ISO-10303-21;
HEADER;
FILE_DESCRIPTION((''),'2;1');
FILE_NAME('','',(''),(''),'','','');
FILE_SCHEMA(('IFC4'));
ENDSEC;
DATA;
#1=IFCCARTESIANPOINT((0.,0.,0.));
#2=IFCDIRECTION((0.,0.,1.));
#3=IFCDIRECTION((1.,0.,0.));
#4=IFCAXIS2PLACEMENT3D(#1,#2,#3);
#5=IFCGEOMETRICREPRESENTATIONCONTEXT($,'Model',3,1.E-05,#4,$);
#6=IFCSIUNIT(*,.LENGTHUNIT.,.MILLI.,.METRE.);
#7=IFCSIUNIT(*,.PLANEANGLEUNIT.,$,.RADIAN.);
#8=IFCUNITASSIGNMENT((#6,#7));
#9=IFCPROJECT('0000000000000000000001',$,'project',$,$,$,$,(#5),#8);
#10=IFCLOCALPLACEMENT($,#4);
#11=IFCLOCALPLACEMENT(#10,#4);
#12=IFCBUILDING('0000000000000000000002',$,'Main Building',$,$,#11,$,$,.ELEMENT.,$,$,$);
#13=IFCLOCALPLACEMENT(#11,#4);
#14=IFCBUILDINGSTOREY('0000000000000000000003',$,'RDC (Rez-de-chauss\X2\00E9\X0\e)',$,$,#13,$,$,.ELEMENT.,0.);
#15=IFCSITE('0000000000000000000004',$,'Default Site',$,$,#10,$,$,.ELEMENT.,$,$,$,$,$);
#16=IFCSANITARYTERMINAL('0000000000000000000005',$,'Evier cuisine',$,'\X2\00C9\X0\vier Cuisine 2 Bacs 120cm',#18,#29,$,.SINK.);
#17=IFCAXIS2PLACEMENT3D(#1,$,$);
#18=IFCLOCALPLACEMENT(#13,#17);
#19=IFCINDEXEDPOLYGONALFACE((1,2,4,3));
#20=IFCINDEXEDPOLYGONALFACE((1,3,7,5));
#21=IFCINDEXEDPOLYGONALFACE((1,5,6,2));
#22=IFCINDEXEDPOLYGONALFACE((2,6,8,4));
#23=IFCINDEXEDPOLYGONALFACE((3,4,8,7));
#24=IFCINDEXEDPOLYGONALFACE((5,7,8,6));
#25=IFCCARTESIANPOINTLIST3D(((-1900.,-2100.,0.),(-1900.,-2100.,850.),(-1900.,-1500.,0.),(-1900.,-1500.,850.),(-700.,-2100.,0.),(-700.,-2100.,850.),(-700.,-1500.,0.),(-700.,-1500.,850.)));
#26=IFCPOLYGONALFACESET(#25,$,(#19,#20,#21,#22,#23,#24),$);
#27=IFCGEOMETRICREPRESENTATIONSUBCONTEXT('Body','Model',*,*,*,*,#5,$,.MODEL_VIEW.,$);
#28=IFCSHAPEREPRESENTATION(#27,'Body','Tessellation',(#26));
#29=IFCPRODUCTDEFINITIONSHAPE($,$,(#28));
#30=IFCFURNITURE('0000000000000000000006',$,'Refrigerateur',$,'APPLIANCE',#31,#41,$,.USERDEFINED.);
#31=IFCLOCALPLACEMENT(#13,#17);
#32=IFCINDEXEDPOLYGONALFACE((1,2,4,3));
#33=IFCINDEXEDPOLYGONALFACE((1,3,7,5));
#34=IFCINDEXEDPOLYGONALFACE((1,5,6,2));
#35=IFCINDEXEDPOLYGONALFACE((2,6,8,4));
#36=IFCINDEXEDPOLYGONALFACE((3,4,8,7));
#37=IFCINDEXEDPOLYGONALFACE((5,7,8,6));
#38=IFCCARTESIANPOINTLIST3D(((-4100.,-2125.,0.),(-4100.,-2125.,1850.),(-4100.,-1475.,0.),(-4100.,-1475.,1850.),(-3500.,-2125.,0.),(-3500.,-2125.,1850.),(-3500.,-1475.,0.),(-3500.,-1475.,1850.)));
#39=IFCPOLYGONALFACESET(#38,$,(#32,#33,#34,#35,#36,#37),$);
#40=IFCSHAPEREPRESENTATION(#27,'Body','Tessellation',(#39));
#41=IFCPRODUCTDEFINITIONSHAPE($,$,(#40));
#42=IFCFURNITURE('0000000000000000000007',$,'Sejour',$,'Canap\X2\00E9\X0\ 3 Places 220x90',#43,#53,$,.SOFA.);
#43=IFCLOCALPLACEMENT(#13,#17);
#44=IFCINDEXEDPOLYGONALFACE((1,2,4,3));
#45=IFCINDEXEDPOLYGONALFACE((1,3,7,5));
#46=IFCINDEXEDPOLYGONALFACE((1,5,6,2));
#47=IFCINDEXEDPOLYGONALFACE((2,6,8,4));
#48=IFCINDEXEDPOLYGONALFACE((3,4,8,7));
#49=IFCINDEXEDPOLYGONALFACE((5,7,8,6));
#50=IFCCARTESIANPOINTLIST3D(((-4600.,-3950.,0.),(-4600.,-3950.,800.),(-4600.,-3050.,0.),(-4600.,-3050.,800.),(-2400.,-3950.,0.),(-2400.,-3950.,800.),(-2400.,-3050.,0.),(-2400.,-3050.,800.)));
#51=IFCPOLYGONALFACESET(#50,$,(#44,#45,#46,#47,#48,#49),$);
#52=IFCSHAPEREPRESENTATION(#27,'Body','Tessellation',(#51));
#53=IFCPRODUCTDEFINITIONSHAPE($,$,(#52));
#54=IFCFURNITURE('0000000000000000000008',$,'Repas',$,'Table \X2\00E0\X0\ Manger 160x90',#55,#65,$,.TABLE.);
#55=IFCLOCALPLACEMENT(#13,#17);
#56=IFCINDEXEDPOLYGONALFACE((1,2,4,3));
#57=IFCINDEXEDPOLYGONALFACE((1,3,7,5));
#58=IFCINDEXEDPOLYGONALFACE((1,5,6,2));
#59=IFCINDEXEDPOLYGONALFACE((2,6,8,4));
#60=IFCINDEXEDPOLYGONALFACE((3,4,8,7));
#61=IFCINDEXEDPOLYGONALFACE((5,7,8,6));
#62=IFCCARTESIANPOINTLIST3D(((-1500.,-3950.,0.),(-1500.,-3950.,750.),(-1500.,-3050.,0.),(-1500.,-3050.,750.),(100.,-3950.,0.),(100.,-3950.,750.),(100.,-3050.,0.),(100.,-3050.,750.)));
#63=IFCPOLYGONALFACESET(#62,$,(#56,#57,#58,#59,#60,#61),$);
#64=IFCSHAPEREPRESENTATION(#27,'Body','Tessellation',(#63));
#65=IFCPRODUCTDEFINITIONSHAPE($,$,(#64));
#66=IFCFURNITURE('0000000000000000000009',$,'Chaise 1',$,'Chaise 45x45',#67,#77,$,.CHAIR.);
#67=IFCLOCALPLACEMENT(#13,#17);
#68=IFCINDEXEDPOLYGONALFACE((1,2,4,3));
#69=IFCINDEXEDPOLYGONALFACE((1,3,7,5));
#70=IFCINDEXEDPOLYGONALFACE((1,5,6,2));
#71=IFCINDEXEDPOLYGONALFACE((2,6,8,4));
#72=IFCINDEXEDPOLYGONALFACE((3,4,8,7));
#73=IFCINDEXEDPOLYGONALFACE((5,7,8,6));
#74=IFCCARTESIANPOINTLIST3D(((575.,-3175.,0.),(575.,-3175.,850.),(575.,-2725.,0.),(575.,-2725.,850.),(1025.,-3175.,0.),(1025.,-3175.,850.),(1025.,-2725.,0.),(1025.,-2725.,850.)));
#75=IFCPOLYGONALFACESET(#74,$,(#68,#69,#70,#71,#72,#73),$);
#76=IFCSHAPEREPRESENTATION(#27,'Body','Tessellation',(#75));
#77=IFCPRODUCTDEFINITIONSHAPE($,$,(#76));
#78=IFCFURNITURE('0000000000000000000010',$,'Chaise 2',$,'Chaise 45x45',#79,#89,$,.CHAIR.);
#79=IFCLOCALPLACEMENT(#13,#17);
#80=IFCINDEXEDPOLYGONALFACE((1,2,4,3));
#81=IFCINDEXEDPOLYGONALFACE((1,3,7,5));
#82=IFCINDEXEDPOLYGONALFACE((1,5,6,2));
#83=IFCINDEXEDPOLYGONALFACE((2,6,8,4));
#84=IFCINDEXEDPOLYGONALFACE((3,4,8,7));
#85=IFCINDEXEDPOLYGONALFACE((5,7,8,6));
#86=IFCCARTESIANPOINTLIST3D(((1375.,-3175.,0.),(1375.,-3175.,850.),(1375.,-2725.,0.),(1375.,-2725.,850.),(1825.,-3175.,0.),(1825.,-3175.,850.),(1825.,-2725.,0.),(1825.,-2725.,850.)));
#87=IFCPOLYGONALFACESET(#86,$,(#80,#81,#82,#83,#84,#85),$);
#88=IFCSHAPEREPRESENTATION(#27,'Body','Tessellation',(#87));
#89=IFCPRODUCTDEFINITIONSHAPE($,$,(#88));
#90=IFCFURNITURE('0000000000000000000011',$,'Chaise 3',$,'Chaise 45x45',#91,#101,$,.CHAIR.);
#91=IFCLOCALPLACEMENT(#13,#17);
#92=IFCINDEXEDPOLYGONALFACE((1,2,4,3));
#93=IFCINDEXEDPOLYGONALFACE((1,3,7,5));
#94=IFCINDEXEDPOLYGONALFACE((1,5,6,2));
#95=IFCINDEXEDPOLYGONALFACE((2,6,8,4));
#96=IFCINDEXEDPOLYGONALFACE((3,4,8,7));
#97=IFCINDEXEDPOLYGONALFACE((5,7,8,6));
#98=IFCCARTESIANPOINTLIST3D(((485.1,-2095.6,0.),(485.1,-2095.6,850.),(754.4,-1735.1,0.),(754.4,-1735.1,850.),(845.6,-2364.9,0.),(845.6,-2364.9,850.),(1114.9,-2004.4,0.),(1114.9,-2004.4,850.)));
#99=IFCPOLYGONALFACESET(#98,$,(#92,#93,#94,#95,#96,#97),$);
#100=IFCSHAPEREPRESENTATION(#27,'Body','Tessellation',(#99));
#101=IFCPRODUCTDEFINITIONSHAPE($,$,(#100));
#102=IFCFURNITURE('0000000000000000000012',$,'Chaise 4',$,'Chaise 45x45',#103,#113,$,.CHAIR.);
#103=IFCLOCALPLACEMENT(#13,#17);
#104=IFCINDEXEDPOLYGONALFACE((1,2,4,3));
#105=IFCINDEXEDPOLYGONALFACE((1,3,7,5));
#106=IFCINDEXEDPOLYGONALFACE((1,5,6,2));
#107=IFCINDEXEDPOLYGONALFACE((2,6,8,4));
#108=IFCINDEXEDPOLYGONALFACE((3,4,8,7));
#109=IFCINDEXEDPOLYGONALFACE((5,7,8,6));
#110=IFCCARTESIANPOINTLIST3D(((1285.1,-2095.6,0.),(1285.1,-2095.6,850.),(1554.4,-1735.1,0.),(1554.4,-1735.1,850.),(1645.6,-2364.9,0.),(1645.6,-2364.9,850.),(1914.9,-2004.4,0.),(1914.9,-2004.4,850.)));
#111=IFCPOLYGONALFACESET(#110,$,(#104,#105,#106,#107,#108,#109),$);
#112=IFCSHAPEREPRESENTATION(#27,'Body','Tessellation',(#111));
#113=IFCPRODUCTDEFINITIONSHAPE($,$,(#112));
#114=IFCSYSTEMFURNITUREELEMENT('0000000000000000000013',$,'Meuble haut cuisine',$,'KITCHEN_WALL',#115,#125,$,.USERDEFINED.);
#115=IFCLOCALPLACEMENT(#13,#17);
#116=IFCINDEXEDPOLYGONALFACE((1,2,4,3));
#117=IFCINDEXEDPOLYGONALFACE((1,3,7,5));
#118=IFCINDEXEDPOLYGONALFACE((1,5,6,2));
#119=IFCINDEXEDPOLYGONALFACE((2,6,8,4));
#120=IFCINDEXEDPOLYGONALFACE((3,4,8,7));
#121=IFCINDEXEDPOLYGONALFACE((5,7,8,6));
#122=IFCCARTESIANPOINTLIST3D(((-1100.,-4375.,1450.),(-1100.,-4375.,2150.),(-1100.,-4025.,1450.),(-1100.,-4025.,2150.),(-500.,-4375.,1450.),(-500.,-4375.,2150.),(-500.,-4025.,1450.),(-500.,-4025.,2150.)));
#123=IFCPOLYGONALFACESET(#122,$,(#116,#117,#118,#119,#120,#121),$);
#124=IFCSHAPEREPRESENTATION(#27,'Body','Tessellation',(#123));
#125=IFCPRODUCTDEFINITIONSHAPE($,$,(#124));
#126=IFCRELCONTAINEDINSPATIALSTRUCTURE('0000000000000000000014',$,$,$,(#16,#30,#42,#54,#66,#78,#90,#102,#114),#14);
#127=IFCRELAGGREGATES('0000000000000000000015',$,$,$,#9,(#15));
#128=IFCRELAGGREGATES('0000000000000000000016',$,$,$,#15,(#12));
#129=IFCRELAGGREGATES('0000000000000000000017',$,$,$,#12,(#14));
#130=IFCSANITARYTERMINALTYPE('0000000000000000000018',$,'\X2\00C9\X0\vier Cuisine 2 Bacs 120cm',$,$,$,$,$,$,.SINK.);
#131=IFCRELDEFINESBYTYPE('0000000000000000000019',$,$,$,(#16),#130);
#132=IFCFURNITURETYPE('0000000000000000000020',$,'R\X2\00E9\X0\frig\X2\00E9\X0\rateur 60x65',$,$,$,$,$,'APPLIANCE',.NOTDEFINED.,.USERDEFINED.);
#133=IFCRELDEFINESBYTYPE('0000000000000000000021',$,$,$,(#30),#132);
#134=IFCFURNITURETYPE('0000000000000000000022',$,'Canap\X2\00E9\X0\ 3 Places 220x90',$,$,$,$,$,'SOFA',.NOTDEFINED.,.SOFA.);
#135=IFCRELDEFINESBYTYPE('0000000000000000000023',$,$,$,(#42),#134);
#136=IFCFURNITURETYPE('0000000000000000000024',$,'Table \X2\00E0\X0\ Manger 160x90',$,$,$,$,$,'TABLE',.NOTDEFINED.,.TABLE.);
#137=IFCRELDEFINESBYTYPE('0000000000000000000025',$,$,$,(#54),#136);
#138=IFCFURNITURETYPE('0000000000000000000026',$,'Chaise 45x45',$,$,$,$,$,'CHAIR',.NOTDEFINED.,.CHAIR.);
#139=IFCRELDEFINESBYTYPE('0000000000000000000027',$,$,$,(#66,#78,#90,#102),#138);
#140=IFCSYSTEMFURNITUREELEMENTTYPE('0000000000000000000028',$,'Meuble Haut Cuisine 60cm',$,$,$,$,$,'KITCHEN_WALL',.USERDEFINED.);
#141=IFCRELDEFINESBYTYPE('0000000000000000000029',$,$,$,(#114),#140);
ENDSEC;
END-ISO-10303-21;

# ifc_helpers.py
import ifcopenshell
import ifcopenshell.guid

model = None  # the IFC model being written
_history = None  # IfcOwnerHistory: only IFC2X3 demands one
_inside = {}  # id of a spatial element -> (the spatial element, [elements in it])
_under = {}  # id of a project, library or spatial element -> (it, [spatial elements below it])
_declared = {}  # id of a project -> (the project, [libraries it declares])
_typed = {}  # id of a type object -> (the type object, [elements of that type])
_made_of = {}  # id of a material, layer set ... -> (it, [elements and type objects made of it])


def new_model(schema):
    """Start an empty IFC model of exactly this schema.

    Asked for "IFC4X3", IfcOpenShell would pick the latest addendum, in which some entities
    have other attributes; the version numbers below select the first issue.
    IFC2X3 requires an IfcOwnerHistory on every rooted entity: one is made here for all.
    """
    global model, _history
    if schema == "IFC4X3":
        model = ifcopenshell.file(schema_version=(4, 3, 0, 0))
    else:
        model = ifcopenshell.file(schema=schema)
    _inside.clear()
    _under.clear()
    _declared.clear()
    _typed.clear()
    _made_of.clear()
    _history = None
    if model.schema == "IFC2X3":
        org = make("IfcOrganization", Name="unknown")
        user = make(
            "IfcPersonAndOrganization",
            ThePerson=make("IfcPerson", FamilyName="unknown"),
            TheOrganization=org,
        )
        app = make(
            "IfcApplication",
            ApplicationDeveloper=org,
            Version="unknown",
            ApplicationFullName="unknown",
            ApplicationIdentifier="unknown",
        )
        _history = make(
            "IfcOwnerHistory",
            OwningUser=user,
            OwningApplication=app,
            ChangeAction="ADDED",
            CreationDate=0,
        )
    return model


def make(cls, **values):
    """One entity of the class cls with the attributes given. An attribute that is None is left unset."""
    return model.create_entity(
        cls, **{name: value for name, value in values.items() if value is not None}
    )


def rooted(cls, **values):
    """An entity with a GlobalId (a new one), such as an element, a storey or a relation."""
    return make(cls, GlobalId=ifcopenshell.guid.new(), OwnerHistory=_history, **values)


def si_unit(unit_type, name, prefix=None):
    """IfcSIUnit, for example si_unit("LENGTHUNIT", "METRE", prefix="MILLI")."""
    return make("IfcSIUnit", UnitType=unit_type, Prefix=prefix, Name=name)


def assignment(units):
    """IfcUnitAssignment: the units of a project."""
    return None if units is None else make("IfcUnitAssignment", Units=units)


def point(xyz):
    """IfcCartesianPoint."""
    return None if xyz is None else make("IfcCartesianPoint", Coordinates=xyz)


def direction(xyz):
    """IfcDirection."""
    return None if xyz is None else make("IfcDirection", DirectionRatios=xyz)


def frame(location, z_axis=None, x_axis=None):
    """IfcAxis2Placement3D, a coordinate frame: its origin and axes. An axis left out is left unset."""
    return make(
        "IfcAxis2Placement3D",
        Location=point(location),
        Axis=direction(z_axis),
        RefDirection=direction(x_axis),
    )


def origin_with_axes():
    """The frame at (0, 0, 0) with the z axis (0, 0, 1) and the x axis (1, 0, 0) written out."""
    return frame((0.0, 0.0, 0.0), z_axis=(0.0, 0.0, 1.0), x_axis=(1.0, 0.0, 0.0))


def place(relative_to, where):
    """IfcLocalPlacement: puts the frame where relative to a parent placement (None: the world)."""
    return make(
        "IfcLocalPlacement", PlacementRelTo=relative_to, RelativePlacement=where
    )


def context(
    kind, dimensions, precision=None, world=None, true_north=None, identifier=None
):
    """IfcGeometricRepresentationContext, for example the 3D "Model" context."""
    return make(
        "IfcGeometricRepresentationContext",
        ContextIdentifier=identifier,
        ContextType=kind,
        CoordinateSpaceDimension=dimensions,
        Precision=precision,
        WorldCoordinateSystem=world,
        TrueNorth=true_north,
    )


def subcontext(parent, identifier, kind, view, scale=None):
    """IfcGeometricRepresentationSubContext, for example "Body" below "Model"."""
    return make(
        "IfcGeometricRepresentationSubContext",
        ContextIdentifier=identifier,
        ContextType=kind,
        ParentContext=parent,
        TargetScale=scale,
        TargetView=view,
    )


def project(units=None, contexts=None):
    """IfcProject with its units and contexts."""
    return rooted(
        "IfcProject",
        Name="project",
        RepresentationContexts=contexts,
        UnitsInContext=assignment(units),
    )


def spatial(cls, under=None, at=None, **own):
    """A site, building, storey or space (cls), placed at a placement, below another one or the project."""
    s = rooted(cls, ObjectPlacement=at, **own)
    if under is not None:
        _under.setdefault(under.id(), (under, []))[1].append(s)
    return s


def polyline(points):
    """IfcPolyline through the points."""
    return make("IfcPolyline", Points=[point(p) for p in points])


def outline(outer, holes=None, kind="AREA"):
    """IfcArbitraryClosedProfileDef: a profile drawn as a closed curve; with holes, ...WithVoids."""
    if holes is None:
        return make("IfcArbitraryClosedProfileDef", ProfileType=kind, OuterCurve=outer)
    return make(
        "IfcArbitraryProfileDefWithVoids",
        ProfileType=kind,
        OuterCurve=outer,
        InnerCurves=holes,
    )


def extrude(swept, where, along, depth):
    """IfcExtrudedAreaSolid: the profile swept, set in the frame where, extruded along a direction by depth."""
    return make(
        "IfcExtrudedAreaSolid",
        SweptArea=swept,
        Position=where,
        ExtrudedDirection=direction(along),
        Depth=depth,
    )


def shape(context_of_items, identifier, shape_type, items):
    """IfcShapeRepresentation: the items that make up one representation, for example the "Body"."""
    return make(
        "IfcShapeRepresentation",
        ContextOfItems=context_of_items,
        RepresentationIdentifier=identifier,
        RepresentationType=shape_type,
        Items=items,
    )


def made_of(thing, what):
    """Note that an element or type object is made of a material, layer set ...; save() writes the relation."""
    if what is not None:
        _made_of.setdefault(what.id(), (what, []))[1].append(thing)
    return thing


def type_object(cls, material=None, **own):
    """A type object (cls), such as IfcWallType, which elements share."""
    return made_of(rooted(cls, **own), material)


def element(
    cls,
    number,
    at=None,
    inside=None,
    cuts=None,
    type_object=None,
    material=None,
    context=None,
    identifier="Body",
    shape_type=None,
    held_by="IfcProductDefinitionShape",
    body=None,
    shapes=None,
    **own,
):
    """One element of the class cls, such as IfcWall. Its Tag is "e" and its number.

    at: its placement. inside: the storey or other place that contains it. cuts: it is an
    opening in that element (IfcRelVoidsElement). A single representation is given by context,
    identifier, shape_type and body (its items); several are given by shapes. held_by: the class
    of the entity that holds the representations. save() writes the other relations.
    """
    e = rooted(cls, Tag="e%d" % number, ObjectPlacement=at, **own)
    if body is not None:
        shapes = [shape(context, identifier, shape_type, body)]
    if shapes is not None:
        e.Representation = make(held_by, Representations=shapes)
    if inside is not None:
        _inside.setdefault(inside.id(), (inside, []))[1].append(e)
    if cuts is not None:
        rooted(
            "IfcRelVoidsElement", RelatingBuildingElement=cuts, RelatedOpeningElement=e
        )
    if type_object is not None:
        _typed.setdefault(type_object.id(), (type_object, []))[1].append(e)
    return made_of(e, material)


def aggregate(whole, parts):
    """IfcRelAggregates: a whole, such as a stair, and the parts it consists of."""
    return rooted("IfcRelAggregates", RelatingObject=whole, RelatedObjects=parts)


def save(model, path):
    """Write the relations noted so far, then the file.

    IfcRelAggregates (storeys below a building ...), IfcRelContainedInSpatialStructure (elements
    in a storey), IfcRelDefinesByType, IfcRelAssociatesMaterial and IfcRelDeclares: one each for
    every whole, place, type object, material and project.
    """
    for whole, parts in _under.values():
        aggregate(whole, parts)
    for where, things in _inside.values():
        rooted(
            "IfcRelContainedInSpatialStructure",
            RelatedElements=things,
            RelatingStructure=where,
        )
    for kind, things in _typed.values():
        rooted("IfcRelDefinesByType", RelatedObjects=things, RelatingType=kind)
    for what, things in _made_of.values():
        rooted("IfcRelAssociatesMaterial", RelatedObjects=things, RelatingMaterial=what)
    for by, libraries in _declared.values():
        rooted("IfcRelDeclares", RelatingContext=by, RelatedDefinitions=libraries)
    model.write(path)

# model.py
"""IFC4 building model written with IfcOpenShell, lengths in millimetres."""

from ifc_helpers import new_model, si_unit, frame, origin_with_axes, place, context, subcontext, project, spatial, polyline, outline, extrude, type_object, element, save


model = new_model("IFC4")

# Units and contexts
model_context = context("Model", 3, precision=1e-05, world=origin_with_axes())
body_context = subcontext(model_context, "Body", "Model", "MODEL_VIEW")
ifc_project = project(units=[si_unit("LENGTHUNIT", "METRE", prefix="MILLI"), si_unit("PLANEANGLEUNIT", "RADIAN")], contexts=[model_context])

# Site, building, storey
site_placement = place(None, origin_with_axes())
site = spatial("IfcSite", under=ifc_project, at=site_placement, Name="Default Site", CompositionType="ELEMENT")
building_placement = place(site_placement, origin_with_axes())
building = spatial("IfcBuilding", under=site, at=building_placement, Name="Main Building", CompositionType="ELEMENT")
storey_placement = place(building_placement, origin_with_axes())
storey = spatial("IfcBuildingStorey", under=building, at=storey_placement, Name="RDC (Rez-de-chaussée)", CompositionType="ELEMENT", Elevation=0.0)

# Sanitary terminal
sanitary_terminal_type = type_object("IfcSanitaryTerminalType", Name="Évier Cuisine 2 Bacs 120cm", PredefinedType="SINK")
sanitary_terminal_placement = place(storey_placement, frame((-1300.0, -1800.0, 0.0), z_axis=(0.0, 0.0, 1.0), x_axis=(1.0, 0.0, 0.0)))
element("IfcSanitaryTerminal", 1, at=sanitary_terminal_placement, inside=storey, type_object=sanitary_terminal_type, Name="Evier cuisine", ObjectType="Évier Cuisine 2 Bacs 120cm", PredefinedType="SINK", context=body_context, shape_type="SweptSolid", body=[
    extrude(outline(polyline([(-600.0, -300.0), (600.0, -300.0), (600.0, 300.0), (-600.0, 300.0), (-600.0, -300.0)])), origin_with_axes(), (0.0, 0.0, 1.0), 850.0),
])

# Furniture
furniture_type_1 = type_object("IfcFurnitureType", Name="Réfrigérateur 60x65", ElementType="APPLIANCE", AssemblyPlace="NOTDEFINED", PredefinedType="USERDEFINED")
furniture_1_placement = place(storey_placement, frame((-3800.0, -1800.0, 0.0), z_axis=(0.0, 0.0, 1.0), x_axis=(1.0, 0.0, 0.0)))
element("IfcFurniture", 2, at=furniture_1_placement, inside=storey, type_object=furniture_type_1, Name="Refrigerateur", ObjectType="APPLIANCE", PredefinedType="USERDEFINED", context=body_context, shape_type="SweptSolid", body=[
    extrude(outline(polyline([(-300.0, -325.0), (300.0, -325.0), (300.0, 325.0), (-300.0, 325.0), (-300.0, -325.0)])), origin_with_axes(), (0.0, 0.0, 1.0), 1850.0),
])
furniture_type_2 = type_object("IfcFurnitureType", Name="Canapé 3 Places 220x90", ElementType="SOFA", AssemblyPlace="NOTDEFINED", PredefinedType="SOFA")
furniture_2_placement = place(storey_placement, frame((-3500.0, -3500.0, 0.0), z_axis=(0.0, 0.0, 1.0), x_axis=(1.0, 0.0, 0.0)))
element("IfcFurniture", 3, at=furniture_2_placement, inside=storey, type_object=furniture_type_2, Name="Sejour", ObjectType="Canapé 3 Places 220x90", PredefinedType="SOFA", context=body_context, shape_type="SweptSolid", body=[
    extrude(outline(polyline([(-1100.0, -450.0), (1100.0, -450.0), (1100.0, 450.0), (-1100.0, 450.0), (-1100.0, -450.0)])), origin_with_axes(), (0.0, 0.0, 1.0), 800.0),
])
furniture_type_3 = type_object("IfcFurnitureType", Name="Table à Manger 160x90", ElementType="TABLE", AssemblyPlace="NOTDEFINED", PredefinedType="TABLE")
furniture_3_placement = place(storey_placement, frame((-700.0, -3500.0, 0.0), z_axis=(0.0, 0.0, 1.0), x_axis=(1.0, 0.0, 0.0)))
element("IfcFurniture", 4, at=furniture_3_placement, inside=storey, type_object=furniture_type_3, Name="Repas", ObjectType="Table à Manger 160x90", PredefinedType="TABLE", context=body_context, shape_type="SweptSolid", body=[
    extrude(outline(polyline([(-800.0, -450.0), (800.0, -450.0), (800.0, 450.0), (-800.0, 450.0), (-800.0, -450.0)])), origin_with_axes(), (0.0, 0.0, 1.0), 750.0),
])
furniture_type_4 = type_object("IfcFurnitureType", Name="Chaise 45x45", ElementType="CHAIR", AssemblyPlace="NOTDEFINED", PredefinedType="CHAIR")
for number, where, z_axis, x_axis, name in (
    (5, (800.0, -2950.0, 0.0), (0.0, 0.0, 1.0), (1.0, 0.0, 0.0), "Chaise 1"),
    (6, (1600.0, -2950.0, 0.0), (0.0, 0.0, 1.0), (1.0, 0.0, 0.0), "Chaise 2"),
    (7, (800.0, -2050.0, 0.0), (0.0, 0.0, 1.0), (-0.59846, -0.801153, 0.0), "Chaise 3"),
    (8, (1600.0, -2050.0, 0.0), (0.0, 0.0, 1.0), (-0.59846, -0.801153, 0.0), "Chaise 4"),
):
    element("IfcFurniture", number, at=place(storey_placement, frame(where, z_axis=z_axis, x_axis=x_axis)), inside=storey, type_object=furniture_type_4, Name=name, ObjectType="Chaise 45x45", PredefinedType="CHAIR", context=body_context, shape_type="SweptSolid", body=[
        extrude(outline(polyline([(-225.0, -225.0), (225.0, -225.0), (225.0, 225.0), (-225.0, 225.0), (-225.0, -225.0)])), origin_with_axes(), (0.0, 0.0, 1.0), 850.0),
    ])

# System furniture element
system_furniture_element_type = type_object("IfcSystemFurnitureElementType", Name="Meuble Haut Cuisine 60cm", ElementType="KITCHEN_WALL", PredefinedType="USERDEFINED")
system_furniture_element_placement = place(storey_placement, frame((-800.0, -4200.0, 1450.0), z_axis=(0.0, 0.0, 1.0), x_axis=(1.0, 0.0, 0.0)))
element("IfcSystemFurnitureElement", 9, at=system_furniture_element_placement, inside=storey, type_object=system_furniture_element_type, Name="Meuble haut cuisine", ObjectType="KITCHEN_WALL", PredefinedType="USERDEFINED", context=body_context, shape_type="SweptSolid", body=[
    extrude(outline(polyline([(-300.0, -175.0), (300.0, -175.0), (300.0, 175.0), (-300.0, 175.0), (-300.0, -175.0)])), origin_with_axes(), (0.0, 0.0, 1.0), 700.0),
])

save(model, "model.ifc")
